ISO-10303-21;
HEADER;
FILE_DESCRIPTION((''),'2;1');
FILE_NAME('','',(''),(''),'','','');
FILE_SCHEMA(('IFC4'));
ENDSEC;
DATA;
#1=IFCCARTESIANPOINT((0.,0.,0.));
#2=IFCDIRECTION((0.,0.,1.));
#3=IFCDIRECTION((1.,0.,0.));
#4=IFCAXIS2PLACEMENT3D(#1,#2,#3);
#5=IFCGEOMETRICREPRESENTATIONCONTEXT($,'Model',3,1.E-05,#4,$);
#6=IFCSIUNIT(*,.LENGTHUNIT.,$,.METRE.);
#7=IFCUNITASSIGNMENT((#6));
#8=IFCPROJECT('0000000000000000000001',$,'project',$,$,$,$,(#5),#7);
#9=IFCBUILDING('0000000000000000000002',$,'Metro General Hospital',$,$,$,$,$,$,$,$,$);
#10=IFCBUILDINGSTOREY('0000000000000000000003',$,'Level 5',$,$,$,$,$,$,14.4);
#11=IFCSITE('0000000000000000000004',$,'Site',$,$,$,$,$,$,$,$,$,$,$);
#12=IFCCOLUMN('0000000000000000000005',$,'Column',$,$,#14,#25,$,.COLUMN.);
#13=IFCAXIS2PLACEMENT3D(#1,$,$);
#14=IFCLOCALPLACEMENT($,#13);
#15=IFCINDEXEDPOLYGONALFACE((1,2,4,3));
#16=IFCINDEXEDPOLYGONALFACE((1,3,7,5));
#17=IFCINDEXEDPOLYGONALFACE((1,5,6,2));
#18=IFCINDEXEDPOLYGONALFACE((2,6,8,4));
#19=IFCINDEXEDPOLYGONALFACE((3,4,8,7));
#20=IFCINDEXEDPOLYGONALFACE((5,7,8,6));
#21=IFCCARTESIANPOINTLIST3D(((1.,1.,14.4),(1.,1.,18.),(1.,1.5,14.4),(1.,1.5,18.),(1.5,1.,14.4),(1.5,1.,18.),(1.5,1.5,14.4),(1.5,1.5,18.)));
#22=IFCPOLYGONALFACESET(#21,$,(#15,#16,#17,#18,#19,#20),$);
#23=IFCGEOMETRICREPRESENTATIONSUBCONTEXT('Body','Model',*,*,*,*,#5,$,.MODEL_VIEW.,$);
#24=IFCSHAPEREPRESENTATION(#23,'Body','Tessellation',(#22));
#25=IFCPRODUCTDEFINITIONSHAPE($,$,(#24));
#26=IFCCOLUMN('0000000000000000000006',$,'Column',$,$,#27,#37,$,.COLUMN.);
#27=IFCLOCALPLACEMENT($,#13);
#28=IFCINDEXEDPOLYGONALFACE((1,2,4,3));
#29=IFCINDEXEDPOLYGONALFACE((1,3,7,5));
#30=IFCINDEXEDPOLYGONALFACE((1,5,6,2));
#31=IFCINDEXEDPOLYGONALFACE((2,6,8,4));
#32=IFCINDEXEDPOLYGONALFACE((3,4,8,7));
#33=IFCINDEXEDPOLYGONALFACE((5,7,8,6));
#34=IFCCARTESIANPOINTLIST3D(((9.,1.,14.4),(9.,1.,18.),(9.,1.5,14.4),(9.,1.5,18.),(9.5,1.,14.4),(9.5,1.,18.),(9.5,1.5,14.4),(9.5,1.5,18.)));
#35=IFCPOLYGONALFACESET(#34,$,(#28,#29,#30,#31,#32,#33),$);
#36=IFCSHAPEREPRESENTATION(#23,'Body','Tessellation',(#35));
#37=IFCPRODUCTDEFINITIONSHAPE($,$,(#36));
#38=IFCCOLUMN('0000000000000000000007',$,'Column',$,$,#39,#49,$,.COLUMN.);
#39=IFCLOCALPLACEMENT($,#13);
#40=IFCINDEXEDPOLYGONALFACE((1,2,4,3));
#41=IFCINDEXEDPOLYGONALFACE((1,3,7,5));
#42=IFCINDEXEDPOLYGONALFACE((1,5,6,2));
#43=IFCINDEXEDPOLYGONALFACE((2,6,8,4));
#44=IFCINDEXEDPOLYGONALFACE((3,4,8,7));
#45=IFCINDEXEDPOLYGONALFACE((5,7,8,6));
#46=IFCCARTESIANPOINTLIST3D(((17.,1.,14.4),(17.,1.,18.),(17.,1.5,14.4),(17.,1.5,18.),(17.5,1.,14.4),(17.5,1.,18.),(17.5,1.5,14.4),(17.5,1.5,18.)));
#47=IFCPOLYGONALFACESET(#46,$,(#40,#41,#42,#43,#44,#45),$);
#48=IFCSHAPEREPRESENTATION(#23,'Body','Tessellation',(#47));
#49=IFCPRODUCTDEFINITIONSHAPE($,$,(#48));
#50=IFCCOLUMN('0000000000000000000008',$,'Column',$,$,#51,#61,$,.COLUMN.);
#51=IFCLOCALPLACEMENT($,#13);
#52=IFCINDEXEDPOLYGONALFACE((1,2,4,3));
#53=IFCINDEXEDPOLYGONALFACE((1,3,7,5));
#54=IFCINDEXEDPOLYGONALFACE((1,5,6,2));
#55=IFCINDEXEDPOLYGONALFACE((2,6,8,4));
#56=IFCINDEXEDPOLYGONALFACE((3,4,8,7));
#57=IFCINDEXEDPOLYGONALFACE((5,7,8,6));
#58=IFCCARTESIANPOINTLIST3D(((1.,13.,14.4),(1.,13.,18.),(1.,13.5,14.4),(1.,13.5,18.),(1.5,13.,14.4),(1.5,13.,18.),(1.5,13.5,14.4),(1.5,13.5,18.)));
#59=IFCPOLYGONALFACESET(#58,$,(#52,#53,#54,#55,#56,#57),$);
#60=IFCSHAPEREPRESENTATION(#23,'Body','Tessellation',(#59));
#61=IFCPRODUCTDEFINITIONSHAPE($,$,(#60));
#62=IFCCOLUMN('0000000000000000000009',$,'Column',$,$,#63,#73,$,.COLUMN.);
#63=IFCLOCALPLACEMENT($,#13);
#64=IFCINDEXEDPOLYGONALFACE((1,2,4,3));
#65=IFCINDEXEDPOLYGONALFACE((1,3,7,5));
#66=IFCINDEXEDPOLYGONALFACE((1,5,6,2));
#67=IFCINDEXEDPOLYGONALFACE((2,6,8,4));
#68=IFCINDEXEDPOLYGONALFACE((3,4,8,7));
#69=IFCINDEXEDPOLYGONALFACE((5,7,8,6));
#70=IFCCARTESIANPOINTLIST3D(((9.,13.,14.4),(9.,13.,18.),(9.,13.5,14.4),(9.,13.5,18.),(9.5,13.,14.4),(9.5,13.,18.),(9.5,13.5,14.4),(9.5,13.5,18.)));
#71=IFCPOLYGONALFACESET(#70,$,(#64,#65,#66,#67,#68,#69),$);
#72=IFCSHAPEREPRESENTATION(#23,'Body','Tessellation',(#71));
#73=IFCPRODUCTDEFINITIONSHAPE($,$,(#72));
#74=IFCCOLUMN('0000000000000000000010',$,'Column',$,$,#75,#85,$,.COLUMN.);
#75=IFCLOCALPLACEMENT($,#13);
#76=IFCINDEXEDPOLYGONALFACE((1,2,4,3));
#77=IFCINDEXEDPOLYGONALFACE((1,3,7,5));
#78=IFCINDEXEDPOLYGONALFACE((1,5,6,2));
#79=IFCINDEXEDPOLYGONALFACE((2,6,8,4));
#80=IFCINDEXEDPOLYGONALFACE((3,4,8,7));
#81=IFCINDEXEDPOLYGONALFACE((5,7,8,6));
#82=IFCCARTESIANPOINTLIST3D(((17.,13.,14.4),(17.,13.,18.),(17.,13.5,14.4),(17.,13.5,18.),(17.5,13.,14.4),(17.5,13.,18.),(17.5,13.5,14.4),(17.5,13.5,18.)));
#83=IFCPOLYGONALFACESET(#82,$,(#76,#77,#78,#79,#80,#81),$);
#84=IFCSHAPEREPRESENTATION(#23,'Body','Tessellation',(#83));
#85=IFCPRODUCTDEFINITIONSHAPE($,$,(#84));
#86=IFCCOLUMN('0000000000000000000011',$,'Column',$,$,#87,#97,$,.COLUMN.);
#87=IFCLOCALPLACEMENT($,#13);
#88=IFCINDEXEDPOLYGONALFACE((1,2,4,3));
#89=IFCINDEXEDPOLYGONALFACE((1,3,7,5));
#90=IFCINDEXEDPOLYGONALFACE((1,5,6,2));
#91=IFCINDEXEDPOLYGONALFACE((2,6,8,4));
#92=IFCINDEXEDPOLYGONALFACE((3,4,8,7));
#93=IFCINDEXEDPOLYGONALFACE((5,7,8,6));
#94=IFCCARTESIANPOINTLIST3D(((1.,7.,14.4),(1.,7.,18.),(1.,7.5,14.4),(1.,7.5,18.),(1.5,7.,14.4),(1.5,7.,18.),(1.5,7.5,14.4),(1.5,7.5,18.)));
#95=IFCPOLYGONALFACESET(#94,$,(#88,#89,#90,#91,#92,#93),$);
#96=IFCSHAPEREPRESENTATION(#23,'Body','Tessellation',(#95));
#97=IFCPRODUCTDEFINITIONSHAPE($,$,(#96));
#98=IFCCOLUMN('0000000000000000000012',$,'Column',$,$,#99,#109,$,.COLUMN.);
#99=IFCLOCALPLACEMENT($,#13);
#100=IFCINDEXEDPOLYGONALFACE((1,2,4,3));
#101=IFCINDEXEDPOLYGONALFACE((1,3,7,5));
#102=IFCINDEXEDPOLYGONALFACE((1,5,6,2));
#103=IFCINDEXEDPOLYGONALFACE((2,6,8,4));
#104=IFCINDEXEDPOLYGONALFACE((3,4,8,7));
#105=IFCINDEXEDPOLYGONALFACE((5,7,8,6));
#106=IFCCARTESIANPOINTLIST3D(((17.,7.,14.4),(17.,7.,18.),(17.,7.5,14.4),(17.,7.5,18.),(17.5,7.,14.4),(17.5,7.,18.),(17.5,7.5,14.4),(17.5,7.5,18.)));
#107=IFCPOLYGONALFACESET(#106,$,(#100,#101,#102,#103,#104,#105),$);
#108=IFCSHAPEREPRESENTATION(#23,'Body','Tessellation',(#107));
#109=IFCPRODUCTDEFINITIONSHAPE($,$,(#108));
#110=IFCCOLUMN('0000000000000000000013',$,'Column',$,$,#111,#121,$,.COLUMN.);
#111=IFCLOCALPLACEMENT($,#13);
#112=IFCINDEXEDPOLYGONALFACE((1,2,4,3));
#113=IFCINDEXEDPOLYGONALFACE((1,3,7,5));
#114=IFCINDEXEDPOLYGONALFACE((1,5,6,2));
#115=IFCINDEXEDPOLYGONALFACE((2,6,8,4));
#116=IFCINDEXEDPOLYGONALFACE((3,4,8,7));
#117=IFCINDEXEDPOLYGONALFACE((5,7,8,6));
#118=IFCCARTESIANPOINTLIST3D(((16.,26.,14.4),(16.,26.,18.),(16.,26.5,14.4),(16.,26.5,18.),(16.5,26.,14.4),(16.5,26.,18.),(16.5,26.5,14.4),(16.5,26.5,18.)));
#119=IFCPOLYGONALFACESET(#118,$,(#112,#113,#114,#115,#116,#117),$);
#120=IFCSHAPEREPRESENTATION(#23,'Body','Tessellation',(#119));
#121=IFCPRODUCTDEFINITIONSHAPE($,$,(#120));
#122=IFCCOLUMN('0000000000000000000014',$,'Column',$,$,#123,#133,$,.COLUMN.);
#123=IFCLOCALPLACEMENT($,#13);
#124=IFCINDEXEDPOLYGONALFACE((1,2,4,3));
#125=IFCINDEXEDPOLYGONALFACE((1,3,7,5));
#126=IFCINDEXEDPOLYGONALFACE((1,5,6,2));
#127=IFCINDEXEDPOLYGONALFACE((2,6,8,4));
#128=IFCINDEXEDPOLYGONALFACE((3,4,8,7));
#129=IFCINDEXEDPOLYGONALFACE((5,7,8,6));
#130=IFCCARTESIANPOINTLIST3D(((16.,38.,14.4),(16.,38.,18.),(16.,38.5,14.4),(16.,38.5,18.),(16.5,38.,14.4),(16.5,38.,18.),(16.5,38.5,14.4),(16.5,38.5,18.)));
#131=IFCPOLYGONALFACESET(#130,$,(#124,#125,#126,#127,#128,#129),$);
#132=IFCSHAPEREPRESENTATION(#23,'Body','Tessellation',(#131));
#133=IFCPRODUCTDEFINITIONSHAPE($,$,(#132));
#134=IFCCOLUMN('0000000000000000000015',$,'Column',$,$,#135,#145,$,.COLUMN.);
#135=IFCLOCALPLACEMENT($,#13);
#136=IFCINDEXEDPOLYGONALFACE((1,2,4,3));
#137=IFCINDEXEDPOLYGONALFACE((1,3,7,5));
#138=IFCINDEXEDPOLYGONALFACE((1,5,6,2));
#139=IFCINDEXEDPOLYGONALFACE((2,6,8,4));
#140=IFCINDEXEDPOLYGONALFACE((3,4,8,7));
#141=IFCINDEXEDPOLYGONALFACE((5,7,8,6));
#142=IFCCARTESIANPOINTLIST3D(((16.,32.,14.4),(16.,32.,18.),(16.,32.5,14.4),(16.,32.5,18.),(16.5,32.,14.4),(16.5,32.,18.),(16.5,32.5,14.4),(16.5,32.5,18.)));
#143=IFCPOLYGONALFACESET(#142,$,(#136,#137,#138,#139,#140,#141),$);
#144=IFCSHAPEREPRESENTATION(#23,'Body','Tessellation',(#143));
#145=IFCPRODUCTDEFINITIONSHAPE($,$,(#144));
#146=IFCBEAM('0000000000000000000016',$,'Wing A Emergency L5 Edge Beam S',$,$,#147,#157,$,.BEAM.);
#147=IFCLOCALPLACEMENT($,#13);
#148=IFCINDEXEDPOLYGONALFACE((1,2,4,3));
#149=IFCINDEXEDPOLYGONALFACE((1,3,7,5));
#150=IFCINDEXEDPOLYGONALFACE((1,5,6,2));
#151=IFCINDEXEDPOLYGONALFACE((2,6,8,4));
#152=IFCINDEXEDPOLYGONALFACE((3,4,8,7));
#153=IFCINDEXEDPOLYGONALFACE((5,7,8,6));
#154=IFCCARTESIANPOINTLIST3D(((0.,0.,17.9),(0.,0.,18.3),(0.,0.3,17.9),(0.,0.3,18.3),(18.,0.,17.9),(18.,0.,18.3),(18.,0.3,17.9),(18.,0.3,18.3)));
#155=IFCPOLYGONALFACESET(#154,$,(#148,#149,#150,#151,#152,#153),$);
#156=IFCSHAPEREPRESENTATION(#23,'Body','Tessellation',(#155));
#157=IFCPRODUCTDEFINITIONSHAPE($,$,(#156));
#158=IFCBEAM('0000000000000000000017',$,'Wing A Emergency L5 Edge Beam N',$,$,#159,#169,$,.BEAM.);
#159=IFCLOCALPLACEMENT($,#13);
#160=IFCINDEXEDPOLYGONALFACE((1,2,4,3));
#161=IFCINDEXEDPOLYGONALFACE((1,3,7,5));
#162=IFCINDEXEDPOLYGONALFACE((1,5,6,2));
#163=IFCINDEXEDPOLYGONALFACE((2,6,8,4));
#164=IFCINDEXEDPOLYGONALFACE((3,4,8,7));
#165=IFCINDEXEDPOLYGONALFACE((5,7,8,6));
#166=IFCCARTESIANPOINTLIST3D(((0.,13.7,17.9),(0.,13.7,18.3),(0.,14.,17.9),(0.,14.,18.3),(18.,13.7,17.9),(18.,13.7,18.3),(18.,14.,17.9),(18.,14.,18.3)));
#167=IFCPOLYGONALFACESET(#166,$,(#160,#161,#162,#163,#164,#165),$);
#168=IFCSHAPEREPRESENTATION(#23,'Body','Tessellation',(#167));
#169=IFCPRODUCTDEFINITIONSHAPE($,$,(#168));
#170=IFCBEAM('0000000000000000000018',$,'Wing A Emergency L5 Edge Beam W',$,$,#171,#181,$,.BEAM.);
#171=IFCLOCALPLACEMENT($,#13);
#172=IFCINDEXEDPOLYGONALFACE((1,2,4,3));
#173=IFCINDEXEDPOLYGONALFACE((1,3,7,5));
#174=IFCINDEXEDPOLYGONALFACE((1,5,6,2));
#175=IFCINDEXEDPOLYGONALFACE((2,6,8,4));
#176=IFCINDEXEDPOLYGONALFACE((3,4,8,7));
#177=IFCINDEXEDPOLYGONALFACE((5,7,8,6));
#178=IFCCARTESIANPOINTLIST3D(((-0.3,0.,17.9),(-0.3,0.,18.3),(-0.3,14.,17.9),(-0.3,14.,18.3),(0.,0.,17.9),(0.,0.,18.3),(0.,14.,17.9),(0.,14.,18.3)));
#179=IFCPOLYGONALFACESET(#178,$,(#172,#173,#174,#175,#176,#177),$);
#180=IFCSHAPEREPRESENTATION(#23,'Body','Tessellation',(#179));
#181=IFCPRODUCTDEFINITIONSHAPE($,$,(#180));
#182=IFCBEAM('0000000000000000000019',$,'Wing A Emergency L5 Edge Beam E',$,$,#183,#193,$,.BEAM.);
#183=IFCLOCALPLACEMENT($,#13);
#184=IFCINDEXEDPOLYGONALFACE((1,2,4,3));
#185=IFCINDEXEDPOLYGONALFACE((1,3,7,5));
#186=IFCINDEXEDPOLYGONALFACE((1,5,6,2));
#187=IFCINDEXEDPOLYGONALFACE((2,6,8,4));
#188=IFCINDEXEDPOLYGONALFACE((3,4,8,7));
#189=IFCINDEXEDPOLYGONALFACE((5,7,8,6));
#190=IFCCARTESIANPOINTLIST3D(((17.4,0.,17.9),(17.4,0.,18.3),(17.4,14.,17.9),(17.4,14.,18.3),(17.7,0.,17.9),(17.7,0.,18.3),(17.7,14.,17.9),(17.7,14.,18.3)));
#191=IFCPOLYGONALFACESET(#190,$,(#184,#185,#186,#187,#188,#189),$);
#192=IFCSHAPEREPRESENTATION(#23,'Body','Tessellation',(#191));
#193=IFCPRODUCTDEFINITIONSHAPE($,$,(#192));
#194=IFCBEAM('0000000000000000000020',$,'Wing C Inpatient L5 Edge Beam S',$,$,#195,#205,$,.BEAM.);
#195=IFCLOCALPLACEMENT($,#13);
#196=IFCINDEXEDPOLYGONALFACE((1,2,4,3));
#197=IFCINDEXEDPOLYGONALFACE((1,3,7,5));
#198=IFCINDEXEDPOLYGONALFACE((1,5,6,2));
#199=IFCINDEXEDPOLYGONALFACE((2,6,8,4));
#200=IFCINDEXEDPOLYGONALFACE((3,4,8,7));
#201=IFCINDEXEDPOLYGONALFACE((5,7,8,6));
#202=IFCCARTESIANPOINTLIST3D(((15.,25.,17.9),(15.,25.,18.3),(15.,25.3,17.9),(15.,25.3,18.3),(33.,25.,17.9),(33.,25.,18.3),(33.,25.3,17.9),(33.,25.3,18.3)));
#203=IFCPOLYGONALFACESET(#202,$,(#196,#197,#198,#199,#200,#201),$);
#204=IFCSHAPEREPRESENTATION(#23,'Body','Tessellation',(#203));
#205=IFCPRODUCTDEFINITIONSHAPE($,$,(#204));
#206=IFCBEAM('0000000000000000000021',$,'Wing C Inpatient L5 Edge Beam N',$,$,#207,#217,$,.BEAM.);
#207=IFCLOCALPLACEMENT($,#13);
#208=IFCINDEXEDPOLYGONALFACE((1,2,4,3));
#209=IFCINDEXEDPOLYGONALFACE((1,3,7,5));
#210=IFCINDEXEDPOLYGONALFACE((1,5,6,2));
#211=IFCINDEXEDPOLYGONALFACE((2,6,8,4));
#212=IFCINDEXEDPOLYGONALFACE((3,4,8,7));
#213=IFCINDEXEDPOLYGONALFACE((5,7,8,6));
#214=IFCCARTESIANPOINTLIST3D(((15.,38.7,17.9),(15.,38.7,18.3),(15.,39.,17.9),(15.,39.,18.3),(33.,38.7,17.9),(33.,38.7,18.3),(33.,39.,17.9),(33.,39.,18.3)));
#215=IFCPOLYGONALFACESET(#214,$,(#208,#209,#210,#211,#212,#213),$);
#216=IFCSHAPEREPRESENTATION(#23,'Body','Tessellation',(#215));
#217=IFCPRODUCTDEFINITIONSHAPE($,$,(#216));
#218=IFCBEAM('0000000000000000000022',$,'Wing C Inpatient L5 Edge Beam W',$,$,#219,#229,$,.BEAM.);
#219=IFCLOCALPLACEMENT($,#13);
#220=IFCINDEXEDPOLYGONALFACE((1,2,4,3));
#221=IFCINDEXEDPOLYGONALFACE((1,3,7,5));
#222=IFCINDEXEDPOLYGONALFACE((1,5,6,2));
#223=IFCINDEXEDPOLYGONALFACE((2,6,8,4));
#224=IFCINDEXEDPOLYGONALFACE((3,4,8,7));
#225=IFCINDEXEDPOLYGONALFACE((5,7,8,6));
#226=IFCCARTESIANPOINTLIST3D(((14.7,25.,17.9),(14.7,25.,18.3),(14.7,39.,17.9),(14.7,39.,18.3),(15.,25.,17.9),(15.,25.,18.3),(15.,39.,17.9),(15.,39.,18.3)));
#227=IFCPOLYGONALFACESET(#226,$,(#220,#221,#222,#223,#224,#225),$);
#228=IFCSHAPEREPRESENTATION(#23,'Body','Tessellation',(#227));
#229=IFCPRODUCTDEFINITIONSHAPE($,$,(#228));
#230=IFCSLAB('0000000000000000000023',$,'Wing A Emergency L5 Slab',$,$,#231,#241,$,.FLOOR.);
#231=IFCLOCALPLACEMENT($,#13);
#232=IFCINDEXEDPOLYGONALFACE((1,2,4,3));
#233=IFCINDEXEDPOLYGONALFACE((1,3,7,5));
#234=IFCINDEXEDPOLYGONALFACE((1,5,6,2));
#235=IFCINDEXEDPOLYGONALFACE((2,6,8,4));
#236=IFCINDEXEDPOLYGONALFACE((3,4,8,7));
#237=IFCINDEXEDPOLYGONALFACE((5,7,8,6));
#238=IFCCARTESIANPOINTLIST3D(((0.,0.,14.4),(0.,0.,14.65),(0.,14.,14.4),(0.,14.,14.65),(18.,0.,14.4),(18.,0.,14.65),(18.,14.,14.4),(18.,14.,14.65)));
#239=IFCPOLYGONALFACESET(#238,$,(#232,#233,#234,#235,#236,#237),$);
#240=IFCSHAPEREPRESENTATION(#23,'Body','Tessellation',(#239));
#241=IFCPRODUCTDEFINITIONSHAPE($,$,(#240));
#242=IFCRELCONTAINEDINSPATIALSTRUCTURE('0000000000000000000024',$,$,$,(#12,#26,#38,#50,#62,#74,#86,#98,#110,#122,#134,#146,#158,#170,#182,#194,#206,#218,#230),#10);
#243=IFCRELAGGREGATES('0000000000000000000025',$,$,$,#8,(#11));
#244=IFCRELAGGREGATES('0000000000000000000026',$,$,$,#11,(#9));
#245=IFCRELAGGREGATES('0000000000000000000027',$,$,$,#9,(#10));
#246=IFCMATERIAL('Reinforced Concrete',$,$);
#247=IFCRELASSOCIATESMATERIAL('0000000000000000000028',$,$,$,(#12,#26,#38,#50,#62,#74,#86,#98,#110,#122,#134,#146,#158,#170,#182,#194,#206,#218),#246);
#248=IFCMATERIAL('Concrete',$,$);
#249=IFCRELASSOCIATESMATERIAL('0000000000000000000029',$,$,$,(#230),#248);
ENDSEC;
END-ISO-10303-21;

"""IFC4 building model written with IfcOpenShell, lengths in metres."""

from ifc_helpers import new_model, si_unit, frame, origin_with_axes, place, context, subcontext, project, spatial, line, indexed_curve, outline, extrude, material, element, save


model = new_model("IFC4")

# Units and contexts
model_context = context("Model", 3, precision=1e-05, world=origin_with_axes())
body_context = subcontext(model_context, "Body", "Model", "MODEL_VIEW")
ifc_project = project(units=[si_unit("LENGTHUNIT", "METRE")], contexts=[model_context])

# Site, building, storey
site = spatial("IfcSite", under=ifc_project, Name="Site")
building = spatial("IfcBuilding", under=site, Name="Metro General Hospital")
storey = spatial("IfcBuildingStorey", under=building, Name="Level 5", Elevation=14.4)

# Columns
ifc_material_1 = material(Name="Reinforced Concrete")
for number, where, z_axis, x_axis, name in (
    (1, (1.0, 1.0, 14.4), (0.0, 0.0, 1.0), (1.0, 0.0, 0.0), "Column"),
    (2, (9.0, 1.0, 14.4), (0.0, 0.0, 1.0), (1.0, 0.0, 0.0), "Column"),
    (3, (17.0, 1.0, 14.4), (0.0, 0.0, 1.0), (1.0, 0.0, 0.0), "Column"),
    (4, (1.0, 13.0, 14.4), (0.0, 0.0, 1.0), (1.0, 0.0, 0.0), "Column"),
    (5, (9.0, 13.0, 14.4), (0.0, 0.0, 1.0), (1.0, 0.0, 0.0), "Column"),
    (6, (17.0, 13.0, 14.4), (0.0, 0.0, 1.0), (1.0, 0.0, 0.0), "Column"),
    (7, (1.0, 7.0, 14.4), (0.0, 0.0, 1.0), (1.0, 0.0, 0.0), "Column"),
    (8, (17.0, 7.0, 14.4), (0.0, 0.0, 1.0), (1.0, 0.0, 0.0), "Column"),
    (9, (16.0, 26.0, 14.4), (0.0, 0.0, 1.0), (1.0, 0.0, 0.0), "Column"),
    (10, (16.0, 38.0, 14.4), (0.0, 0.0, 1.0), (1.0, 0.0, 0.0), "Column"),
    (11, (16.0, 32.0, 14.4), (0.0, 0.0, 1.0), (1.0, 0.0, 0.0), "Column"),
):
    element("IfcColumn", number, at=place(None, frame(where, z_axis=z_axis, x_axis=x_axis)), inside=storey, material=ifc_material_1, Name=name, PredefinedType="COLUMN", context=body_context, shape_type="SweptSolid", body=[
        extrude(outline(indexed_curve([(0.0, 0.0), (0.5, 0.0), (0.5, 0.5), (0.0, 0.5)], segments=[line(1, 2, 3, 4, 1)])), origin_with_axes(), (0.0, 0.0, 1.0), 3.6),
    ])

# Beams
for number, where, z_axis, x_axis, name in (
    (12, (0.0, 0.0, 17.9), (0.0, 0.0, 1.0), (1.0, 0.0, 0.0), "Wing A Emergency L5 Edge Beam S"),
    (13, (0.0, 13.7, 17.9), (0.0, 0.0, 1.0), (1.0, 0.0, 0.0), "Wing A Emergency L5 Edge Beam N"),
):
    element("IfcBeam", number, at=place(None, frame(where, z_axis=z_axis, x_axis=x_axis)), inside=storey, material=ifc_material_1, Name=name, PredefinedType="BEAM", context=body_context, shape_type="SweptSolid", body=[
        extrude(outline(indexed_curve([(0.0, 0.0), (18.0, 0.0), (18.0, 0.3), (0.0, 0.3)], segments=[line(1, 2, 3, 4, 1)])), origin_with_axes(), (0.0, 0.0, 1.0), 0.4),
    ])
for number, where, z_axis, x_axis, name in (
    (14, (0.0, 0.0, 17.9), (0.0, 0.0, 1.0), (0.0, 1.0, 0.0), "Wing A Emergency L5 Edge Beam W"),
    (15, (17.7, 0.0, 17.9), (0.0, 0.0, 1.0), (0.0, 1.0, 0.0), "Wing A Emergency L5 Edge Beam E"),
):
    element("IfcBeam", number, at=place(None, frame(where, z_axis=z_axis, x_axis=x_axis)), inside=storey, material=ifc_material_1, Name=name, PredefinedType="BEAM", context=body_context, shape_type="SweptSolid", body=[
        extrude(outline(indexed_curve([(0.0, 0.0), (14.0, 0.0), (14.0, 0.3), (0.0, 0.3)], segments=[line(1, 2, 3, 4, 1)])), origin_with_axes(), (0.0, 0.0, 1.0), 0.4),
    ])
for number, where, z_axis, x_axis, name in (
    (16, (15.0, 25.0, 17.9), (0.0, 0.0, 1.0), (1.0, 0.0, 0.0), "Wing C Inpatient L5 Edge Beam S"),
    (17, (15.0, 38.7, 17.9), (0.0, 0.0, 1.0), (1.0, 0.0, 0.0), "Wing C Inpatient L5 Edge Beam N"),
):
    element("IfcBeam", number, at=place(None, frame(where, z_axis=z_axis, x_axis=x_axis)), inside=storey, material=ifc_material_1, Name=name, PredefinedType="BEAM", context=body_context, shape_type="SweptSolid", body=[
        extrude(outline(indexed_curve([(0.0, 0.0), (18.0, 0.0), (18.0, 0.3), (0.0, 0.3)], segments=[line(1, 2, 3, 4, 1)])), origin_with_axes(), (0.0, 0.0, 1.0), 0.4),
    ])
beam_placement = place(None, frame((15.0, 25.0, 17.9), z_axis=(0.0, 0.0, 1.0), x_axis=(0.0, 1.0, 0.0)))
element("IfcBeam", 18, at=beam_placement, inside=storey, material=ifc_material_1, Name="Wing C Inpatient L5 Edge Beam W", PredefinedType="BEAM", context=body_context, shape_type="SweptSolid", body=[
    extrude(outline(indexed_curve([(0.0, 0.0), (14.0, 0.0), (14.0, 0.3), (0.0, 0.3)], segments=[line(1, 2, 3, 4, 1)])), origin_with_axes(), (0.0, 0.0, 1.0), 0.4),
])

# Slab
ifc_material_2 = material(Name="Concrete")
for number, where, z_axis, x_axis, name in (
    (19, (0.0, 0.0, 14.4), (0.0, 0.0, 1.0), (1.0, 0.0, 0.0), "Wing A Emergency L5 Slab"),
):
    element("IfcSlab", number, at=place(None, frame(where, z_axis=z_axis, x_axis=x_axis)), inside=storey, material=ifc_material_2, Name=name, PredefinedType="FLOOR", context=body_context, shape_type="SweptSolid", body=[
        extrude(outline(indexed_curve([(0.0, 0.0), (18.0, 0.0), (18.0, 14.0), (0.0, 14.0)], segments=[line(1, 2, 3, 4, 1)])), origin_with_axes(), (0.0, 0.0, 1.0), 0.25),
    ])

save(model, "model.ifc")
